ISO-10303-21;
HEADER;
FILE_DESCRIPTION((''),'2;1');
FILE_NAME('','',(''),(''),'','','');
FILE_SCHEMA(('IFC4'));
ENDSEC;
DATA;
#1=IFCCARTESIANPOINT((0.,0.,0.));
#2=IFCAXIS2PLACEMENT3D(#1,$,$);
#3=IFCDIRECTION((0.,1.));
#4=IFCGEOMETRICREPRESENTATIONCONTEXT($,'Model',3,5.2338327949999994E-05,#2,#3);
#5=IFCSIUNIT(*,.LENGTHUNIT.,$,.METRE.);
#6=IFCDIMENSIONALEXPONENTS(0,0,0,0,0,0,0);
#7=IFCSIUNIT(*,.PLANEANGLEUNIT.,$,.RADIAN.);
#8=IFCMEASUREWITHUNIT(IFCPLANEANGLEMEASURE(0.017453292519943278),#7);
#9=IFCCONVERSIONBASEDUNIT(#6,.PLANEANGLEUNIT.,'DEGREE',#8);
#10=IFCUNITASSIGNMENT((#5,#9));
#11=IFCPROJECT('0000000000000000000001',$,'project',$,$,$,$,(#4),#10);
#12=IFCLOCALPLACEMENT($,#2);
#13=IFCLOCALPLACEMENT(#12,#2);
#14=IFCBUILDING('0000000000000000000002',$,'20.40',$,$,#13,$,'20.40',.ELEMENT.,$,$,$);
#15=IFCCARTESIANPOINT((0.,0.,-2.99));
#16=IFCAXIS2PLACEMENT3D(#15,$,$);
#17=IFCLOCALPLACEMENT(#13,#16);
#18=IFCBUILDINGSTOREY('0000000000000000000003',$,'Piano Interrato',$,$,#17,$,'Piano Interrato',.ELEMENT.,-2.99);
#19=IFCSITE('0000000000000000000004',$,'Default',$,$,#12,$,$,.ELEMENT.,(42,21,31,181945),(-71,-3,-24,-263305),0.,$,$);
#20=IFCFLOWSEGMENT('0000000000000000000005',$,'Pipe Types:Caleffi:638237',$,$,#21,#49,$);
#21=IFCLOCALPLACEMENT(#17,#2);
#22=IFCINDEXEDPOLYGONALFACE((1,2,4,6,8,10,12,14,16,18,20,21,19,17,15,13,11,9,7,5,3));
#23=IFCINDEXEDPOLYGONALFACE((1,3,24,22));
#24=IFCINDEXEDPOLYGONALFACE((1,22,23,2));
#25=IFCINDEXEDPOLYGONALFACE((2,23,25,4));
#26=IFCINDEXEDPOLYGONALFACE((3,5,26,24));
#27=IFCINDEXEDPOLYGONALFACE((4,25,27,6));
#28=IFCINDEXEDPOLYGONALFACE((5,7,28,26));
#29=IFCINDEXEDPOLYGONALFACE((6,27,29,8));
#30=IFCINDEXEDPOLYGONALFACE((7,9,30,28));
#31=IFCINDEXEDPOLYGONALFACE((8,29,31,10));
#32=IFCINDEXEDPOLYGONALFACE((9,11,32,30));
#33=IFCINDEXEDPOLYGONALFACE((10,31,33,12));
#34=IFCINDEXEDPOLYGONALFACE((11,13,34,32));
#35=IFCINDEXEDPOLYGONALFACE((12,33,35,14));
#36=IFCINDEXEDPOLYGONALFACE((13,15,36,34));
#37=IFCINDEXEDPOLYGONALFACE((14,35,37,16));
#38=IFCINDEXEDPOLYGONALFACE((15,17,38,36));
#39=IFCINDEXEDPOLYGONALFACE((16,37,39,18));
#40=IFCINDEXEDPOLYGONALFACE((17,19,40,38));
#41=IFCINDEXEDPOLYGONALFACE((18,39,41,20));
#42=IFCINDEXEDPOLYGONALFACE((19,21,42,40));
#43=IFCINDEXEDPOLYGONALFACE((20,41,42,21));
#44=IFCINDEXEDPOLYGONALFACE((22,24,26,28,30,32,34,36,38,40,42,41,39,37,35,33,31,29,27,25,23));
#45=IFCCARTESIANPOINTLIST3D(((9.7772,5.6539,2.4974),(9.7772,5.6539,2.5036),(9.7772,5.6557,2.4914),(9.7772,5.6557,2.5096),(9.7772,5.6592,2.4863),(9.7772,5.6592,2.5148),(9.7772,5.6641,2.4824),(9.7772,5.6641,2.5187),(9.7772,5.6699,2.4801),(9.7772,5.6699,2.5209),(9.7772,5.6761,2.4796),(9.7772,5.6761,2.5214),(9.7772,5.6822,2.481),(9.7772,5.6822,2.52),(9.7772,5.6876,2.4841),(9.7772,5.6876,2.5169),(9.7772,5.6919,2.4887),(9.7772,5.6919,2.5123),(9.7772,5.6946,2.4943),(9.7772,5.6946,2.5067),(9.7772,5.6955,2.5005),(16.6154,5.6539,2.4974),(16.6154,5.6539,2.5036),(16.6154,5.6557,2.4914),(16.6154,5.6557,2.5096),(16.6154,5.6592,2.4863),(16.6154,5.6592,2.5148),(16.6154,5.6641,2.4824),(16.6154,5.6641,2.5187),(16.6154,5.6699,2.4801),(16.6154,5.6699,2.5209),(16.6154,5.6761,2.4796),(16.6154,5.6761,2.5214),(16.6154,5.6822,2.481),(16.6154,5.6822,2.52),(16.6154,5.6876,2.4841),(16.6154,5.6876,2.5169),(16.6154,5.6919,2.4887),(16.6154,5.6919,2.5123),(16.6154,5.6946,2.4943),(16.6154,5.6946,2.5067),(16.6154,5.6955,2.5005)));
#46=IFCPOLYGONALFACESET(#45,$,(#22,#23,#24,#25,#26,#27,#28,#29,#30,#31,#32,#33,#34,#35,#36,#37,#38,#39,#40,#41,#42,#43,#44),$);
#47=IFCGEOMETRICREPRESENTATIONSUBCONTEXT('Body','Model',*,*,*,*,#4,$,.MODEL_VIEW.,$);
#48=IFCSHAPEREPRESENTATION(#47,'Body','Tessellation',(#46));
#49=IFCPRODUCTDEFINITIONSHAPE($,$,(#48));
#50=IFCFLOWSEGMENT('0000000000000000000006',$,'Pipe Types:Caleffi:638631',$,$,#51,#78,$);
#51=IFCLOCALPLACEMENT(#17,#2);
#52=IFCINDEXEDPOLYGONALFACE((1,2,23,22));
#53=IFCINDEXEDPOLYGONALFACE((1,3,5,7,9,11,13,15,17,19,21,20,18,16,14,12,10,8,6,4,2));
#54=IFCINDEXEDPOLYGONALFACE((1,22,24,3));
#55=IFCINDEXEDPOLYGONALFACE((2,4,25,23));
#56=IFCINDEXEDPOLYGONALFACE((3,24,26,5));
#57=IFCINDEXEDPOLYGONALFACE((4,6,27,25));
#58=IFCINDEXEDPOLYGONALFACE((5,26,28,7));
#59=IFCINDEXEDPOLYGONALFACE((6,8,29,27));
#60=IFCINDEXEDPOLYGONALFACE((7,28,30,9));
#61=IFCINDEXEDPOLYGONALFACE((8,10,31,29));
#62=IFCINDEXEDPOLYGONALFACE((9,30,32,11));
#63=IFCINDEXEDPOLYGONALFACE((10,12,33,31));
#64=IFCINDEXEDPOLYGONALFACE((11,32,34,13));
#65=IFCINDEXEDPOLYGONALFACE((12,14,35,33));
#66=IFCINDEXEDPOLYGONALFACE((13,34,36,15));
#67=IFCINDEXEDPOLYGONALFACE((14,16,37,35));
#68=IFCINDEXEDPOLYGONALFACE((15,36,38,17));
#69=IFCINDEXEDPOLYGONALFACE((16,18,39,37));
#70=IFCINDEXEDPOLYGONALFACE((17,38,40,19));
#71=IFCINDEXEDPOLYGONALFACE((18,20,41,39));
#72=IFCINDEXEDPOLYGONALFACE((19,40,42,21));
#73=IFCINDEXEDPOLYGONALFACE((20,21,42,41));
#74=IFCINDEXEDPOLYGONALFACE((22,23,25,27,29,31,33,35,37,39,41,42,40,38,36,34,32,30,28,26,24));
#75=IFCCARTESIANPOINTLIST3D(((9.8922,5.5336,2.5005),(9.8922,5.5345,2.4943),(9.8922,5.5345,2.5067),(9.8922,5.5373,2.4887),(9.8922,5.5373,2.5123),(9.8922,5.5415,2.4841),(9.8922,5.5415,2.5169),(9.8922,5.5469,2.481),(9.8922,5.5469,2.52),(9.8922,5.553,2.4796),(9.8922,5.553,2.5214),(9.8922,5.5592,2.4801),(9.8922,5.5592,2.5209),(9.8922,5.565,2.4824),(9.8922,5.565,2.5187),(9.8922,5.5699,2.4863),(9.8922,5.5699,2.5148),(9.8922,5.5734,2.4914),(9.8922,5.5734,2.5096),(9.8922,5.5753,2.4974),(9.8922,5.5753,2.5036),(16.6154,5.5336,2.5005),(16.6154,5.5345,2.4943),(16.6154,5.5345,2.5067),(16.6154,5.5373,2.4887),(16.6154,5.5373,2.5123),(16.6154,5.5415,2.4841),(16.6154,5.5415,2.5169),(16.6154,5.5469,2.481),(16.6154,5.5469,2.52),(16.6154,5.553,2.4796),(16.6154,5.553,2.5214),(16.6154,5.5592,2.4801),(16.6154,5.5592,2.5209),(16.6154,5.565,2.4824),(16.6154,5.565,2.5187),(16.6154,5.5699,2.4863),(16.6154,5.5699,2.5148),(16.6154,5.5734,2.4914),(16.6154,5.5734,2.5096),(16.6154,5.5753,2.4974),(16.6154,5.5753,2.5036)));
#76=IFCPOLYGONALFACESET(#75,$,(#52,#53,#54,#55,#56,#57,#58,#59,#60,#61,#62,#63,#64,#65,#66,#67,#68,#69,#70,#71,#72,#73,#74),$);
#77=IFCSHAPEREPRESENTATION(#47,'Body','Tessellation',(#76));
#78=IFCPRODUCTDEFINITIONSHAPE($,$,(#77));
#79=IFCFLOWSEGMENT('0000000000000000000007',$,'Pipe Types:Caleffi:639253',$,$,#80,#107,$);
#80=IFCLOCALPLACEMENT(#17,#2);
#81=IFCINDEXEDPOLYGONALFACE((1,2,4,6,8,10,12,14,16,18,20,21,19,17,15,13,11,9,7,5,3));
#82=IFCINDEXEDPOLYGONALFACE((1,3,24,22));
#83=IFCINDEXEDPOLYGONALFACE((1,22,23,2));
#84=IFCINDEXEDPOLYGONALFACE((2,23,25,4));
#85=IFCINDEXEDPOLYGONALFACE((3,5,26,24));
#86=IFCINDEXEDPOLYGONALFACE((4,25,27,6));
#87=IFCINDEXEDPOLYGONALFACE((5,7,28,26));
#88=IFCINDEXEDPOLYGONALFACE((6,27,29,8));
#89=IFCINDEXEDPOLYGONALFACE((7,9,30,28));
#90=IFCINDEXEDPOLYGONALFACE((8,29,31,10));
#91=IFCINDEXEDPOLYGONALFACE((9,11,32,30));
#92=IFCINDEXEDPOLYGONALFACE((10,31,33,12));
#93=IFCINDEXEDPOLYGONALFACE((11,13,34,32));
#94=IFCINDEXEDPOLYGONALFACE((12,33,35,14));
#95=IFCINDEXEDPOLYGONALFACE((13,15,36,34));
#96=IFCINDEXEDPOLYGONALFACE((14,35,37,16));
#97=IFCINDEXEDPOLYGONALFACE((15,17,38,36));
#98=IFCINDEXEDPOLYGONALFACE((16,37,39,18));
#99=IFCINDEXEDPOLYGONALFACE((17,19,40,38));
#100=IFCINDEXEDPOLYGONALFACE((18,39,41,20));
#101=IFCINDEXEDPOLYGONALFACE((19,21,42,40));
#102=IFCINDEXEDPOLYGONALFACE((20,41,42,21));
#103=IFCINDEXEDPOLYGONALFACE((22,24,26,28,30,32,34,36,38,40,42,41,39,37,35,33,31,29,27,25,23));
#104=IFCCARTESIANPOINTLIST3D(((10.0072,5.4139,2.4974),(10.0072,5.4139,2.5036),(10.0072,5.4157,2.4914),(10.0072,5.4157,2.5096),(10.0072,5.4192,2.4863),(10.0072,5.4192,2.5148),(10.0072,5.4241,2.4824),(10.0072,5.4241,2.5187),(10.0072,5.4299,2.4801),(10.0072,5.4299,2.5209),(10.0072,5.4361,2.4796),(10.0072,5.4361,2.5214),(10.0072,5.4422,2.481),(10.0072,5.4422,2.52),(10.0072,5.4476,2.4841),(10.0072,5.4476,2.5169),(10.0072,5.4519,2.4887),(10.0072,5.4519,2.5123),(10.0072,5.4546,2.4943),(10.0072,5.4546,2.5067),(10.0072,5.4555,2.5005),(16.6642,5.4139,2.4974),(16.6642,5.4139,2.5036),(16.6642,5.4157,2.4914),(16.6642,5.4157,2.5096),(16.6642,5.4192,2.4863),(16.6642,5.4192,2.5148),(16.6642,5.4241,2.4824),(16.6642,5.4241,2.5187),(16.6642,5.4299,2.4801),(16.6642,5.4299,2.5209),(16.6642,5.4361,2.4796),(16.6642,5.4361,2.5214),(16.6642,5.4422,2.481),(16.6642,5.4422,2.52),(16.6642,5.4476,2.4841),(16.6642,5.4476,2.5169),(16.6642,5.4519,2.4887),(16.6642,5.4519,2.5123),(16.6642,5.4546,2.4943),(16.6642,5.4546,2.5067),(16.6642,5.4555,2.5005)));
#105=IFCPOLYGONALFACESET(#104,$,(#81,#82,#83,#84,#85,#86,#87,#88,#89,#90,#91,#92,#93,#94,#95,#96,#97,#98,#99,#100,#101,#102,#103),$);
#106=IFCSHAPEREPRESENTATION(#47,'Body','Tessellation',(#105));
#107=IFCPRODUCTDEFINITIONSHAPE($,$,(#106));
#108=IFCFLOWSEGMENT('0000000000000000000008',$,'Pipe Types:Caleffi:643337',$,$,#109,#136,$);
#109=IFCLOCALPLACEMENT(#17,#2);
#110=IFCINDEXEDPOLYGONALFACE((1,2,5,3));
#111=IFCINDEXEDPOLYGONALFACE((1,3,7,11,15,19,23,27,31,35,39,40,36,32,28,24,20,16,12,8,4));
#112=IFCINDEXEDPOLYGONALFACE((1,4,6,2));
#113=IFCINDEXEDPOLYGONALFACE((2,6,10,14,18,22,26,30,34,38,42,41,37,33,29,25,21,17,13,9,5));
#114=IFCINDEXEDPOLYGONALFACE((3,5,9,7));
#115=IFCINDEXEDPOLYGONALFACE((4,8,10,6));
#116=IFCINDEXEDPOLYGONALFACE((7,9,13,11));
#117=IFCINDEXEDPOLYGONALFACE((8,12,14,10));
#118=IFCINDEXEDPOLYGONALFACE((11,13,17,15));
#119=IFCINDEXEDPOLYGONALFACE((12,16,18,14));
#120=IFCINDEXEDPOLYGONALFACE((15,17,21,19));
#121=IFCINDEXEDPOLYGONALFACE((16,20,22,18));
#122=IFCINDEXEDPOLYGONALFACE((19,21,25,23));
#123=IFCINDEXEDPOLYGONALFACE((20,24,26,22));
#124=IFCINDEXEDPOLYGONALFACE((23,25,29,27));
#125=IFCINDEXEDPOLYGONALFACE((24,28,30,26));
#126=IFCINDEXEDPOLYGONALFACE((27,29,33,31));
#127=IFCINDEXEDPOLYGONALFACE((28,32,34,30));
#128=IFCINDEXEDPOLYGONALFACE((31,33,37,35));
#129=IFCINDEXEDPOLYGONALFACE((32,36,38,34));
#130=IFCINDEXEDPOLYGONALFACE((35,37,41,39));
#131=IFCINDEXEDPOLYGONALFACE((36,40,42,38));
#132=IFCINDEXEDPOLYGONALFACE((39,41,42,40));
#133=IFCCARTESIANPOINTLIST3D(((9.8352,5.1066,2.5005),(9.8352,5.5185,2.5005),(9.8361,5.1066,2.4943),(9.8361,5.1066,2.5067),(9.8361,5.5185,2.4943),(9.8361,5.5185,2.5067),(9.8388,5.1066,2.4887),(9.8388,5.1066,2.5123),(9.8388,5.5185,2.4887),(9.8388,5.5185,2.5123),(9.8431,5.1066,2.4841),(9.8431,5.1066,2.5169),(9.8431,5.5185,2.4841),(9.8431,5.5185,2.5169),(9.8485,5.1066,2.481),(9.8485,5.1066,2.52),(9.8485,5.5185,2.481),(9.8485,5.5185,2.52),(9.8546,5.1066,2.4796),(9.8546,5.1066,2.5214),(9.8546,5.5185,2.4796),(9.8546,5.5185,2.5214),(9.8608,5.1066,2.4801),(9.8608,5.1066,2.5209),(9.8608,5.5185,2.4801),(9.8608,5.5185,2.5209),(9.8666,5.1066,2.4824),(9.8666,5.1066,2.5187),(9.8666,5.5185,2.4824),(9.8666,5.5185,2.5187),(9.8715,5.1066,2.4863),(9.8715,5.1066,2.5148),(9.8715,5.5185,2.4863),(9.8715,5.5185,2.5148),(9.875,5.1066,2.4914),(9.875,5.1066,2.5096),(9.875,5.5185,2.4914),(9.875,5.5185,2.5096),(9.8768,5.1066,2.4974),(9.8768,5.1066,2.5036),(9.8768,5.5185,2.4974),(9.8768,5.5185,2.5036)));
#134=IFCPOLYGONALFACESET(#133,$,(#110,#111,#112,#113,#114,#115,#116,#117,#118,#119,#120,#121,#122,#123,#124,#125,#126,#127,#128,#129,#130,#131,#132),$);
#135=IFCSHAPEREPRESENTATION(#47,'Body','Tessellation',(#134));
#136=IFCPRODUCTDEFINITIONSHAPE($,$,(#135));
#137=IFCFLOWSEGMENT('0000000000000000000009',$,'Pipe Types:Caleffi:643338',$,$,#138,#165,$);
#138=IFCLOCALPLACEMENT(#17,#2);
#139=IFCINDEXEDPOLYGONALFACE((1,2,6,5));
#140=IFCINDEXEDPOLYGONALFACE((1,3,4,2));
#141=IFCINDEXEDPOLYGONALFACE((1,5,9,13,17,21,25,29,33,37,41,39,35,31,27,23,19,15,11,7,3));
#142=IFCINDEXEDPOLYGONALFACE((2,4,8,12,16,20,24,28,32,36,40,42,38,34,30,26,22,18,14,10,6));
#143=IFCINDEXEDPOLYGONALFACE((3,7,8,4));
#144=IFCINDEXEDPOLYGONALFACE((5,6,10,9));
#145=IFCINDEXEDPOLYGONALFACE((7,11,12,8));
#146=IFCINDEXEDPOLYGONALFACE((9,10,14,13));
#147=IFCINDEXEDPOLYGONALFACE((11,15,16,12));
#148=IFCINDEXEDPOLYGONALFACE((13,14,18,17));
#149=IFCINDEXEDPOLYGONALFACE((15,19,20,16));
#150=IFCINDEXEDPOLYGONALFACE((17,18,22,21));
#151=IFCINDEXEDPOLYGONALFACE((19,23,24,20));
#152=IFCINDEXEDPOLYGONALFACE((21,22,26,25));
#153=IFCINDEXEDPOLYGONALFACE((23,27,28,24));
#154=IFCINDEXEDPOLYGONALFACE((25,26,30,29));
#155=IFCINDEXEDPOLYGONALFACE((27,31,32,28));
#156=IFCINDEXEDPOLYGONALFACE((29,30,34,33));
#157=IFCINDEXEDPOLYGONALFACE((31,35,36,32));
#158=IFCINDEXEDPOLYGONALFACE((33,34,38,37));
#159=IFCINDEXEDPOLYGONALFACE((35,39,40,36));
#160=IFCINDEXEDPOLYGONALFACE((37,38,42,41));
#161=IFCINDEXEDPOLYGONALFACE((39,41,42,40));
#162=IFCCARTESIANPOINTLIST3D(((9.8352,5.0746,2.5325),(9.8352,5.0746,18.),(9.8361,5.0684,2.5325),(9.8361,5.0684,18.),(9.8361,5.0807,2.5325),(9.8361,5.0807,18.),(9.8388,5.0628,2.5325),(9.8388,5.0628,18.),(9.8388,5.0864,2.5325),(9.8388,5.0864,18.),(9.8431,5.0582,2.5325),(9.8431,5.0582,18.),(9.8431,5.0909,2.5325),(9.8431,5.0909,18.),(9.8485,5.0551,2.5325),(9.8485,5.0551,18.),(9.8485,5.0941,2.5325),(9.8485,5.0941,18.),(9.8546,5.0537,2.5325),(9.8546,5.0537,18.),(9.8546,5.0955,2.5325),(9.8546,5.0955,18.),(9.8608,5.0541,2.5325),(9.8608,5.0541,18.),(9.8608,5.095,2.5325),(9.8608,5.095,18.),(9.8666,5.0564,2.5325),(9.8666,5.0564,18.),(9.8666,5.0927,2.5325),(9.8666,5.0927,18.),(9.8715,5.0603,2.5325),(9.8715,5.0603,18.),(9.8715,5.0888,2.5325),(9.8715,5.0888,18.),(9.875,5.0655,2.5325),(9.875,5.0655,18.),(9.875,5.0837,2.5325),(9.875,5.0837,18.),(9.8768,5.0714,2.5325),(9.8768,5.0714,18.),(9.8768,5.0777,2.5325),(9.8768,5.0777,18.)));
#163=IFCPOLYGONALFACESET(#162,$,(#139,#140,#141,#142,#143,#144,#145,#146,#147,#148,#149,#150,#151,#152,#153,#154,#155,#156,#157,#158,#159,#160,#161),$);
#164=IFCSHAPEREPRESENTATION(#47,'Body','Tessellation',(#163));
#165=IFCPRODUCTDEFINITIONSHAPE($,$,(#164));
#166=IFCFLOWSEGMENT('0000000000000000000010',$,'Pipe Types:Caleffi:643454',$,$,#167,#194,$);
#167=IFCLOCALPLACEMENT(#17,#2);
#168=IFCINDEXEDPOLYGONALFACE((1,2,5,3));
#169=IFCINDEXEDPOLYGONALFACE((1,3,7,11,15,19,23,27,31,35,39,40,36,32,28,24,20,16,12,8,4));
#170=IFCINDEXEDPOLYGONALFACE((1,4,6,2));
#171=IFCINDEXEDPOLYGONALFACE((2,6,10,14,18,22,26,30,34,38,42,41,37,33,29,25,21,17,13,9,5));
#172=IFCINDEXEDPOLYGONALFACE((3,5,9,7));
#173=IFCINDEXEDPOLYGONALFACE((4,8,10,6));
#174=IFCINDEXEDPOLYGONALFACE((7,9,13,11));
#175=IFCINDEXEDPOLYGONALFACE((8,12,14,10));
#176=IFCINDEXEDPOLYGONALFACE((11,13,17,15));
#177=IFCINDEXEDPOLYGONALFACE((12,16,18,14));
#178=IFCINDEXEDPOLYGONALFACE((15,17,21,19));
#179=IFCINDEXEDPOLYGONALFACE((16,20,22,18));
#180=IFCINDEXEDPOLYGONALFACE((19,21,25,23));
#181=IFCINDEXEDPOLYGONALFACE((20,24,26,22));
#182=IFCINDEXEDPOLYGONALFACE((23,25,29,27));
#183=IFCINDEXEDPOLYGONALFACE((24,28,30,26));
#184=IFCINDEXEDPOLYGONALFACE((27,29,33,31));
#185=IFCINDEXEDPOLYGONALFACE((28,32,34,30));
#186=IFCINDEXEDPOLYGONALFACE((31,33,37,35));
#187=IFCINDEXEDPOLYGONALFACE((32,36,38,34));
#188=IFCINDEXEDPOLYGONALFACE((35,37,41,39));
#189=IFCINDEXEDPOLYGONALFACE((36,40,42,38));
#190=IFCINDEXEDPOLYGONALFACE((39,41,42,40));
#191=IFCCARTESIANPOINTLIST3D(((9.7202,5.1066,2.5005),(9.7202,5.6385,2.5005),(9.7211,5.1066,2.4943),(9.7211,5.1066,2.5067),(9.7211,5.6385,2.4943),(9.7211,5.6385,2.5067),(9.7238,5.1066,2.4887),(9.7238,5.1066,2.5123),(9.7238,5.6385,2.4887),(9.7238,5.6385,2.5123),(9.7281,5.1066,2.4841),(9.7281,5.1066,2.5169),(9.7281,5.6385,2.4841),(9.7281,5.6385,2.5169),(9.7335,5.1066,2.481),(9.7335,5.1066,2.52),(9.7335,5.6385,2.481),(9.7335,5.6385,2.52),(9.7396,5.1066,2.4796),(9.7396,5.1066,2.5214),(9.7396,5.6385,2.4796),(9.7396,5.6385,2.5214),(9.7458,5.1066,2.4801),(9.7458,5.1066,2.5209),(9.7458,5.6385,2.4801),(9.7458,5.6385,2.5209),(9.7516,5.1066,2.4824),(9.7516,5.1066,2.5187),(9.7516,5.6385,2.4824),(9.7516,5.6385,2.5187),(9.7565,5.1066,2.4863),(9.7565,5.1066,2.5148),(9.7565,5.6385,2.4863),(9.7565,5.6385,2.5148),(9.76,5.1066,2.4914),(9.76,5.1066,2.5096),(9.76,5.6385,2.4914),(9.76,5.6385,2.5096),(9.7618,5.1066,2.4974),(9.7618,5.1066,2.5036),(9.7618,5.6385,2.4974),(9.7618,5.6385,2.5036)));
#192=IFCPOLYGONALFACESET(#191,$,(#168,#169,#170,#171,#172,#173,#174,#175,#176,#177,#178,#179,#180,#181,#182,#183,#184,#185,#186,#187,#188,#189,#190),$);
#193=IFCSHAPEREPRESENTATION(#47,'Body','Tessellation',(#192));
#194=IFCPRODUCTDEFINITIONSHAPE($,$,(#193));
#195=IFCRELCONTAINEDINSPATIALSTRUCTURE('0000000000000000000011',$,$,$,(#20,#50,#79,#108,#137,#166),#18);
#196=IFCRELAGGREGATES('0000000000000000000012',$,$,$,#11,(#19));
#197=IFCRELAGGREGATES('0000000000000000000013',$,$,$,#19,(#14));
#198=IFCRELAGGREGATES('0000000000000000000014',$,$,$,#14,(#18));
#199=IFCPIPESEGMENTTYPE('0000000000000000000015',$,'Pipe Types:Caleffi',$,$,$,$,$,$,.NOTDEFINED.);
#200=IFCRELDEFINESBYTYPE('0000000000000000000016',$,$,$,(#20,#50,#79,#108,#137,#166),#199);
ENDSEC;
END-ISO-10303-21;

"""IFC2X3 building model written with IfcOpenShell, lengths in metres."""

from ifc_helpers import new_model, entity, si_unit, converted_unit, direction, frame, frame_2d, origin, origin_2d_with_axis, place, context, subcontext, project, spatial, circle, extrude, type_object, element, save


model = new_model("IFC2X3")

# Units and contexts
model_context = context("Model", 3, precision=5.2338327949999994e-05, world=origin(), true_north=direction((0.0, 1.0)))
body_context = subcontext(model_context, "Body", "Model", "MODEL_VIEW")
ifc_project = project(units=[si_unit("LENGTHUNIT", "METRE"), converted_unit("PLANEANGLEUNIT", "DEGREE", entity("IfcPlaneAngleMeasure", 0.017453292519943278), si_unit("PLANEANGLEUNIT", "RADIAN"), dimensions=[0, 0, 0, 0, 0, 0, 0])], contexts=[model_context])

# Site, building, storey
site_placement = place(None, origin())
site = spatial("IfcSite", under=ifc_project, at=site_placement, Name="Default", CompositionType="ELEMENT", RefLatitude=(42, 21, 31, 181945), RefLongitude=(-71, -3, -24, -263305), RefElevation=0.0)
building_placement = place(site_placement, origin())
building = spatial("IfcBuilding", under=site, at=building_placement, Name="20.40", LongName="20.40", CompositionType="ELEMENT")
storey_placement = place(building_placement, frame((0.0, 0.0, -2.99)))
storey = spatial("IfcBuildingStorey", under=building, at=storey_placement, Name="Piano Interrato", LongName="Piano Interrato", CompositionType="ELEMENT", Elevation=-2.99)

# Flow segments
pipe_segment_type_1 = type_object("IfcPipeSegmentType", Name="Pipe Types:Caleffi", PredefinedType="NOTDEFINED")
flow_segment_1_placement = place(storey_placement, origin())
element("IfcFlowSegment", 1, at=flow_segment_1_placement, inside=storey, type_object=pipe_segment_type_1, Name="Pipe Types:Caleffi:638237", context=body_context, shape_type="SweptSolid", body=[
    extrude(circle(Radius=0.0209, at=frame_2d((0.0, 0.0), x_axis=(1.0, 0.0))), frame((9.7772, 5.6746, 2.5005), z_axis=(1.0, 0.0, 0.0), x_axis=(0.0, 1.0, 0.0)), (0.0, 0.0, 1.0), 6.8381),
])
flow_segment_2_placement = place(storey_placement, origin())
element("IfcFlowSegment", 2, at=flow_segment_2_placement, inside=storey, type_object=pipe_segment_type_1, Name="Pipe Types:Caleffi:638631", context=body_context, shape_type="SweptSolid", body=[
    extrude(circle(Radius=0.0209, at=origin_2d_with_axis()), frame((9.8922, 5.5546, 2.5005), z_axis=(1.0, 0.0, 0.0), x_axis=(0.0, -1.0, 0.0)), (0.0, 0.0, 1.0), 6.7231),
])
flow_segment_3_placement = place(storey_placement, origin())
element("IfcFlowSegment", 3, at=flow_segment_3_placement, inside=storey, type_object=pipe_segment_type_1, Name="Pipe Types:Caleffi:639253", context=body_context, shape_type="SweptSolid", body=[
    extrude(circle(Radius=0.0209, at=frame_2d((0.0, 0.0), x_axis=(1.0, 0.0))), frame((10.0072, 5.4346, 2.5005), z_axis=(1.0, 0.0, 0.0), x_axis=(0.0, 1.0, 0.0)), (0.0, 0.0, 1.0), 6.6569),
])
flow_segment_4_placement = place(storey_placement, origin())
element("IfcFlowSegment", 4, at=flow_segment_4_placement, inside=storey, type_object=pipe_segment_type_1, Name="Pipe Types:Caleffi:643337", context=body_context, shape_type="SweptSolid", body=[
    extrude(circle(Radius=0.0209, at=frame_2d((0.0, 0.0), x_axis=(1.0, 0.0))), frame((9.8561, 5.1066, 2.5005), z_axis=(0.0, 1.0, 0.0), x_axis=(-1.0, 0.0, 0.0)), (0.0, 0.0, 1.0), 0.4119),
])
flow_segment_5_placement = place(storey_placement, origin())
element("IfcFlowSegment", 5, at=flow_segment_5_placement, inside=storey, type_object=pipe_segment_type_1, Name="Pipe Types:Caleffi:643338", context=body_context, shape_type="SweptSolid", body=[
    extrude(circle(Radius=0.0209, at=origin_2d_with_axis()), frame((9.8561, 5.0746, 2.5325), z_axis=(0.0, 0.0, 1.0), x_axis=(-1.0, 0.0, 0.0)), (0.0, 0.0, 1.0), 15.4675),
])
flow_segment_6_placement = place(storey_placement, origin())
element("IfcFlowSegment", 6, at=flow_segment_6_placement, inside=storey, type_object=pipe_segment_type_1, Name="Pipe Types:Caleffi:643454", context=body_context, shape_type="SweptSolid", body=[
    extrude(circle(Radius=0.0209, at=frame_2d((0.0, 0.0), x_axis=(1.0, 0.0))), frame((9.7411, 5.1066, 2.5005), z_axis=(0.0, 1.0, 0.0), x_axis=(-1.0, 0.0, 0.0)), (0.0, 0.0, 1.0), 0.5319),
])

save(model, "model.ifc")
